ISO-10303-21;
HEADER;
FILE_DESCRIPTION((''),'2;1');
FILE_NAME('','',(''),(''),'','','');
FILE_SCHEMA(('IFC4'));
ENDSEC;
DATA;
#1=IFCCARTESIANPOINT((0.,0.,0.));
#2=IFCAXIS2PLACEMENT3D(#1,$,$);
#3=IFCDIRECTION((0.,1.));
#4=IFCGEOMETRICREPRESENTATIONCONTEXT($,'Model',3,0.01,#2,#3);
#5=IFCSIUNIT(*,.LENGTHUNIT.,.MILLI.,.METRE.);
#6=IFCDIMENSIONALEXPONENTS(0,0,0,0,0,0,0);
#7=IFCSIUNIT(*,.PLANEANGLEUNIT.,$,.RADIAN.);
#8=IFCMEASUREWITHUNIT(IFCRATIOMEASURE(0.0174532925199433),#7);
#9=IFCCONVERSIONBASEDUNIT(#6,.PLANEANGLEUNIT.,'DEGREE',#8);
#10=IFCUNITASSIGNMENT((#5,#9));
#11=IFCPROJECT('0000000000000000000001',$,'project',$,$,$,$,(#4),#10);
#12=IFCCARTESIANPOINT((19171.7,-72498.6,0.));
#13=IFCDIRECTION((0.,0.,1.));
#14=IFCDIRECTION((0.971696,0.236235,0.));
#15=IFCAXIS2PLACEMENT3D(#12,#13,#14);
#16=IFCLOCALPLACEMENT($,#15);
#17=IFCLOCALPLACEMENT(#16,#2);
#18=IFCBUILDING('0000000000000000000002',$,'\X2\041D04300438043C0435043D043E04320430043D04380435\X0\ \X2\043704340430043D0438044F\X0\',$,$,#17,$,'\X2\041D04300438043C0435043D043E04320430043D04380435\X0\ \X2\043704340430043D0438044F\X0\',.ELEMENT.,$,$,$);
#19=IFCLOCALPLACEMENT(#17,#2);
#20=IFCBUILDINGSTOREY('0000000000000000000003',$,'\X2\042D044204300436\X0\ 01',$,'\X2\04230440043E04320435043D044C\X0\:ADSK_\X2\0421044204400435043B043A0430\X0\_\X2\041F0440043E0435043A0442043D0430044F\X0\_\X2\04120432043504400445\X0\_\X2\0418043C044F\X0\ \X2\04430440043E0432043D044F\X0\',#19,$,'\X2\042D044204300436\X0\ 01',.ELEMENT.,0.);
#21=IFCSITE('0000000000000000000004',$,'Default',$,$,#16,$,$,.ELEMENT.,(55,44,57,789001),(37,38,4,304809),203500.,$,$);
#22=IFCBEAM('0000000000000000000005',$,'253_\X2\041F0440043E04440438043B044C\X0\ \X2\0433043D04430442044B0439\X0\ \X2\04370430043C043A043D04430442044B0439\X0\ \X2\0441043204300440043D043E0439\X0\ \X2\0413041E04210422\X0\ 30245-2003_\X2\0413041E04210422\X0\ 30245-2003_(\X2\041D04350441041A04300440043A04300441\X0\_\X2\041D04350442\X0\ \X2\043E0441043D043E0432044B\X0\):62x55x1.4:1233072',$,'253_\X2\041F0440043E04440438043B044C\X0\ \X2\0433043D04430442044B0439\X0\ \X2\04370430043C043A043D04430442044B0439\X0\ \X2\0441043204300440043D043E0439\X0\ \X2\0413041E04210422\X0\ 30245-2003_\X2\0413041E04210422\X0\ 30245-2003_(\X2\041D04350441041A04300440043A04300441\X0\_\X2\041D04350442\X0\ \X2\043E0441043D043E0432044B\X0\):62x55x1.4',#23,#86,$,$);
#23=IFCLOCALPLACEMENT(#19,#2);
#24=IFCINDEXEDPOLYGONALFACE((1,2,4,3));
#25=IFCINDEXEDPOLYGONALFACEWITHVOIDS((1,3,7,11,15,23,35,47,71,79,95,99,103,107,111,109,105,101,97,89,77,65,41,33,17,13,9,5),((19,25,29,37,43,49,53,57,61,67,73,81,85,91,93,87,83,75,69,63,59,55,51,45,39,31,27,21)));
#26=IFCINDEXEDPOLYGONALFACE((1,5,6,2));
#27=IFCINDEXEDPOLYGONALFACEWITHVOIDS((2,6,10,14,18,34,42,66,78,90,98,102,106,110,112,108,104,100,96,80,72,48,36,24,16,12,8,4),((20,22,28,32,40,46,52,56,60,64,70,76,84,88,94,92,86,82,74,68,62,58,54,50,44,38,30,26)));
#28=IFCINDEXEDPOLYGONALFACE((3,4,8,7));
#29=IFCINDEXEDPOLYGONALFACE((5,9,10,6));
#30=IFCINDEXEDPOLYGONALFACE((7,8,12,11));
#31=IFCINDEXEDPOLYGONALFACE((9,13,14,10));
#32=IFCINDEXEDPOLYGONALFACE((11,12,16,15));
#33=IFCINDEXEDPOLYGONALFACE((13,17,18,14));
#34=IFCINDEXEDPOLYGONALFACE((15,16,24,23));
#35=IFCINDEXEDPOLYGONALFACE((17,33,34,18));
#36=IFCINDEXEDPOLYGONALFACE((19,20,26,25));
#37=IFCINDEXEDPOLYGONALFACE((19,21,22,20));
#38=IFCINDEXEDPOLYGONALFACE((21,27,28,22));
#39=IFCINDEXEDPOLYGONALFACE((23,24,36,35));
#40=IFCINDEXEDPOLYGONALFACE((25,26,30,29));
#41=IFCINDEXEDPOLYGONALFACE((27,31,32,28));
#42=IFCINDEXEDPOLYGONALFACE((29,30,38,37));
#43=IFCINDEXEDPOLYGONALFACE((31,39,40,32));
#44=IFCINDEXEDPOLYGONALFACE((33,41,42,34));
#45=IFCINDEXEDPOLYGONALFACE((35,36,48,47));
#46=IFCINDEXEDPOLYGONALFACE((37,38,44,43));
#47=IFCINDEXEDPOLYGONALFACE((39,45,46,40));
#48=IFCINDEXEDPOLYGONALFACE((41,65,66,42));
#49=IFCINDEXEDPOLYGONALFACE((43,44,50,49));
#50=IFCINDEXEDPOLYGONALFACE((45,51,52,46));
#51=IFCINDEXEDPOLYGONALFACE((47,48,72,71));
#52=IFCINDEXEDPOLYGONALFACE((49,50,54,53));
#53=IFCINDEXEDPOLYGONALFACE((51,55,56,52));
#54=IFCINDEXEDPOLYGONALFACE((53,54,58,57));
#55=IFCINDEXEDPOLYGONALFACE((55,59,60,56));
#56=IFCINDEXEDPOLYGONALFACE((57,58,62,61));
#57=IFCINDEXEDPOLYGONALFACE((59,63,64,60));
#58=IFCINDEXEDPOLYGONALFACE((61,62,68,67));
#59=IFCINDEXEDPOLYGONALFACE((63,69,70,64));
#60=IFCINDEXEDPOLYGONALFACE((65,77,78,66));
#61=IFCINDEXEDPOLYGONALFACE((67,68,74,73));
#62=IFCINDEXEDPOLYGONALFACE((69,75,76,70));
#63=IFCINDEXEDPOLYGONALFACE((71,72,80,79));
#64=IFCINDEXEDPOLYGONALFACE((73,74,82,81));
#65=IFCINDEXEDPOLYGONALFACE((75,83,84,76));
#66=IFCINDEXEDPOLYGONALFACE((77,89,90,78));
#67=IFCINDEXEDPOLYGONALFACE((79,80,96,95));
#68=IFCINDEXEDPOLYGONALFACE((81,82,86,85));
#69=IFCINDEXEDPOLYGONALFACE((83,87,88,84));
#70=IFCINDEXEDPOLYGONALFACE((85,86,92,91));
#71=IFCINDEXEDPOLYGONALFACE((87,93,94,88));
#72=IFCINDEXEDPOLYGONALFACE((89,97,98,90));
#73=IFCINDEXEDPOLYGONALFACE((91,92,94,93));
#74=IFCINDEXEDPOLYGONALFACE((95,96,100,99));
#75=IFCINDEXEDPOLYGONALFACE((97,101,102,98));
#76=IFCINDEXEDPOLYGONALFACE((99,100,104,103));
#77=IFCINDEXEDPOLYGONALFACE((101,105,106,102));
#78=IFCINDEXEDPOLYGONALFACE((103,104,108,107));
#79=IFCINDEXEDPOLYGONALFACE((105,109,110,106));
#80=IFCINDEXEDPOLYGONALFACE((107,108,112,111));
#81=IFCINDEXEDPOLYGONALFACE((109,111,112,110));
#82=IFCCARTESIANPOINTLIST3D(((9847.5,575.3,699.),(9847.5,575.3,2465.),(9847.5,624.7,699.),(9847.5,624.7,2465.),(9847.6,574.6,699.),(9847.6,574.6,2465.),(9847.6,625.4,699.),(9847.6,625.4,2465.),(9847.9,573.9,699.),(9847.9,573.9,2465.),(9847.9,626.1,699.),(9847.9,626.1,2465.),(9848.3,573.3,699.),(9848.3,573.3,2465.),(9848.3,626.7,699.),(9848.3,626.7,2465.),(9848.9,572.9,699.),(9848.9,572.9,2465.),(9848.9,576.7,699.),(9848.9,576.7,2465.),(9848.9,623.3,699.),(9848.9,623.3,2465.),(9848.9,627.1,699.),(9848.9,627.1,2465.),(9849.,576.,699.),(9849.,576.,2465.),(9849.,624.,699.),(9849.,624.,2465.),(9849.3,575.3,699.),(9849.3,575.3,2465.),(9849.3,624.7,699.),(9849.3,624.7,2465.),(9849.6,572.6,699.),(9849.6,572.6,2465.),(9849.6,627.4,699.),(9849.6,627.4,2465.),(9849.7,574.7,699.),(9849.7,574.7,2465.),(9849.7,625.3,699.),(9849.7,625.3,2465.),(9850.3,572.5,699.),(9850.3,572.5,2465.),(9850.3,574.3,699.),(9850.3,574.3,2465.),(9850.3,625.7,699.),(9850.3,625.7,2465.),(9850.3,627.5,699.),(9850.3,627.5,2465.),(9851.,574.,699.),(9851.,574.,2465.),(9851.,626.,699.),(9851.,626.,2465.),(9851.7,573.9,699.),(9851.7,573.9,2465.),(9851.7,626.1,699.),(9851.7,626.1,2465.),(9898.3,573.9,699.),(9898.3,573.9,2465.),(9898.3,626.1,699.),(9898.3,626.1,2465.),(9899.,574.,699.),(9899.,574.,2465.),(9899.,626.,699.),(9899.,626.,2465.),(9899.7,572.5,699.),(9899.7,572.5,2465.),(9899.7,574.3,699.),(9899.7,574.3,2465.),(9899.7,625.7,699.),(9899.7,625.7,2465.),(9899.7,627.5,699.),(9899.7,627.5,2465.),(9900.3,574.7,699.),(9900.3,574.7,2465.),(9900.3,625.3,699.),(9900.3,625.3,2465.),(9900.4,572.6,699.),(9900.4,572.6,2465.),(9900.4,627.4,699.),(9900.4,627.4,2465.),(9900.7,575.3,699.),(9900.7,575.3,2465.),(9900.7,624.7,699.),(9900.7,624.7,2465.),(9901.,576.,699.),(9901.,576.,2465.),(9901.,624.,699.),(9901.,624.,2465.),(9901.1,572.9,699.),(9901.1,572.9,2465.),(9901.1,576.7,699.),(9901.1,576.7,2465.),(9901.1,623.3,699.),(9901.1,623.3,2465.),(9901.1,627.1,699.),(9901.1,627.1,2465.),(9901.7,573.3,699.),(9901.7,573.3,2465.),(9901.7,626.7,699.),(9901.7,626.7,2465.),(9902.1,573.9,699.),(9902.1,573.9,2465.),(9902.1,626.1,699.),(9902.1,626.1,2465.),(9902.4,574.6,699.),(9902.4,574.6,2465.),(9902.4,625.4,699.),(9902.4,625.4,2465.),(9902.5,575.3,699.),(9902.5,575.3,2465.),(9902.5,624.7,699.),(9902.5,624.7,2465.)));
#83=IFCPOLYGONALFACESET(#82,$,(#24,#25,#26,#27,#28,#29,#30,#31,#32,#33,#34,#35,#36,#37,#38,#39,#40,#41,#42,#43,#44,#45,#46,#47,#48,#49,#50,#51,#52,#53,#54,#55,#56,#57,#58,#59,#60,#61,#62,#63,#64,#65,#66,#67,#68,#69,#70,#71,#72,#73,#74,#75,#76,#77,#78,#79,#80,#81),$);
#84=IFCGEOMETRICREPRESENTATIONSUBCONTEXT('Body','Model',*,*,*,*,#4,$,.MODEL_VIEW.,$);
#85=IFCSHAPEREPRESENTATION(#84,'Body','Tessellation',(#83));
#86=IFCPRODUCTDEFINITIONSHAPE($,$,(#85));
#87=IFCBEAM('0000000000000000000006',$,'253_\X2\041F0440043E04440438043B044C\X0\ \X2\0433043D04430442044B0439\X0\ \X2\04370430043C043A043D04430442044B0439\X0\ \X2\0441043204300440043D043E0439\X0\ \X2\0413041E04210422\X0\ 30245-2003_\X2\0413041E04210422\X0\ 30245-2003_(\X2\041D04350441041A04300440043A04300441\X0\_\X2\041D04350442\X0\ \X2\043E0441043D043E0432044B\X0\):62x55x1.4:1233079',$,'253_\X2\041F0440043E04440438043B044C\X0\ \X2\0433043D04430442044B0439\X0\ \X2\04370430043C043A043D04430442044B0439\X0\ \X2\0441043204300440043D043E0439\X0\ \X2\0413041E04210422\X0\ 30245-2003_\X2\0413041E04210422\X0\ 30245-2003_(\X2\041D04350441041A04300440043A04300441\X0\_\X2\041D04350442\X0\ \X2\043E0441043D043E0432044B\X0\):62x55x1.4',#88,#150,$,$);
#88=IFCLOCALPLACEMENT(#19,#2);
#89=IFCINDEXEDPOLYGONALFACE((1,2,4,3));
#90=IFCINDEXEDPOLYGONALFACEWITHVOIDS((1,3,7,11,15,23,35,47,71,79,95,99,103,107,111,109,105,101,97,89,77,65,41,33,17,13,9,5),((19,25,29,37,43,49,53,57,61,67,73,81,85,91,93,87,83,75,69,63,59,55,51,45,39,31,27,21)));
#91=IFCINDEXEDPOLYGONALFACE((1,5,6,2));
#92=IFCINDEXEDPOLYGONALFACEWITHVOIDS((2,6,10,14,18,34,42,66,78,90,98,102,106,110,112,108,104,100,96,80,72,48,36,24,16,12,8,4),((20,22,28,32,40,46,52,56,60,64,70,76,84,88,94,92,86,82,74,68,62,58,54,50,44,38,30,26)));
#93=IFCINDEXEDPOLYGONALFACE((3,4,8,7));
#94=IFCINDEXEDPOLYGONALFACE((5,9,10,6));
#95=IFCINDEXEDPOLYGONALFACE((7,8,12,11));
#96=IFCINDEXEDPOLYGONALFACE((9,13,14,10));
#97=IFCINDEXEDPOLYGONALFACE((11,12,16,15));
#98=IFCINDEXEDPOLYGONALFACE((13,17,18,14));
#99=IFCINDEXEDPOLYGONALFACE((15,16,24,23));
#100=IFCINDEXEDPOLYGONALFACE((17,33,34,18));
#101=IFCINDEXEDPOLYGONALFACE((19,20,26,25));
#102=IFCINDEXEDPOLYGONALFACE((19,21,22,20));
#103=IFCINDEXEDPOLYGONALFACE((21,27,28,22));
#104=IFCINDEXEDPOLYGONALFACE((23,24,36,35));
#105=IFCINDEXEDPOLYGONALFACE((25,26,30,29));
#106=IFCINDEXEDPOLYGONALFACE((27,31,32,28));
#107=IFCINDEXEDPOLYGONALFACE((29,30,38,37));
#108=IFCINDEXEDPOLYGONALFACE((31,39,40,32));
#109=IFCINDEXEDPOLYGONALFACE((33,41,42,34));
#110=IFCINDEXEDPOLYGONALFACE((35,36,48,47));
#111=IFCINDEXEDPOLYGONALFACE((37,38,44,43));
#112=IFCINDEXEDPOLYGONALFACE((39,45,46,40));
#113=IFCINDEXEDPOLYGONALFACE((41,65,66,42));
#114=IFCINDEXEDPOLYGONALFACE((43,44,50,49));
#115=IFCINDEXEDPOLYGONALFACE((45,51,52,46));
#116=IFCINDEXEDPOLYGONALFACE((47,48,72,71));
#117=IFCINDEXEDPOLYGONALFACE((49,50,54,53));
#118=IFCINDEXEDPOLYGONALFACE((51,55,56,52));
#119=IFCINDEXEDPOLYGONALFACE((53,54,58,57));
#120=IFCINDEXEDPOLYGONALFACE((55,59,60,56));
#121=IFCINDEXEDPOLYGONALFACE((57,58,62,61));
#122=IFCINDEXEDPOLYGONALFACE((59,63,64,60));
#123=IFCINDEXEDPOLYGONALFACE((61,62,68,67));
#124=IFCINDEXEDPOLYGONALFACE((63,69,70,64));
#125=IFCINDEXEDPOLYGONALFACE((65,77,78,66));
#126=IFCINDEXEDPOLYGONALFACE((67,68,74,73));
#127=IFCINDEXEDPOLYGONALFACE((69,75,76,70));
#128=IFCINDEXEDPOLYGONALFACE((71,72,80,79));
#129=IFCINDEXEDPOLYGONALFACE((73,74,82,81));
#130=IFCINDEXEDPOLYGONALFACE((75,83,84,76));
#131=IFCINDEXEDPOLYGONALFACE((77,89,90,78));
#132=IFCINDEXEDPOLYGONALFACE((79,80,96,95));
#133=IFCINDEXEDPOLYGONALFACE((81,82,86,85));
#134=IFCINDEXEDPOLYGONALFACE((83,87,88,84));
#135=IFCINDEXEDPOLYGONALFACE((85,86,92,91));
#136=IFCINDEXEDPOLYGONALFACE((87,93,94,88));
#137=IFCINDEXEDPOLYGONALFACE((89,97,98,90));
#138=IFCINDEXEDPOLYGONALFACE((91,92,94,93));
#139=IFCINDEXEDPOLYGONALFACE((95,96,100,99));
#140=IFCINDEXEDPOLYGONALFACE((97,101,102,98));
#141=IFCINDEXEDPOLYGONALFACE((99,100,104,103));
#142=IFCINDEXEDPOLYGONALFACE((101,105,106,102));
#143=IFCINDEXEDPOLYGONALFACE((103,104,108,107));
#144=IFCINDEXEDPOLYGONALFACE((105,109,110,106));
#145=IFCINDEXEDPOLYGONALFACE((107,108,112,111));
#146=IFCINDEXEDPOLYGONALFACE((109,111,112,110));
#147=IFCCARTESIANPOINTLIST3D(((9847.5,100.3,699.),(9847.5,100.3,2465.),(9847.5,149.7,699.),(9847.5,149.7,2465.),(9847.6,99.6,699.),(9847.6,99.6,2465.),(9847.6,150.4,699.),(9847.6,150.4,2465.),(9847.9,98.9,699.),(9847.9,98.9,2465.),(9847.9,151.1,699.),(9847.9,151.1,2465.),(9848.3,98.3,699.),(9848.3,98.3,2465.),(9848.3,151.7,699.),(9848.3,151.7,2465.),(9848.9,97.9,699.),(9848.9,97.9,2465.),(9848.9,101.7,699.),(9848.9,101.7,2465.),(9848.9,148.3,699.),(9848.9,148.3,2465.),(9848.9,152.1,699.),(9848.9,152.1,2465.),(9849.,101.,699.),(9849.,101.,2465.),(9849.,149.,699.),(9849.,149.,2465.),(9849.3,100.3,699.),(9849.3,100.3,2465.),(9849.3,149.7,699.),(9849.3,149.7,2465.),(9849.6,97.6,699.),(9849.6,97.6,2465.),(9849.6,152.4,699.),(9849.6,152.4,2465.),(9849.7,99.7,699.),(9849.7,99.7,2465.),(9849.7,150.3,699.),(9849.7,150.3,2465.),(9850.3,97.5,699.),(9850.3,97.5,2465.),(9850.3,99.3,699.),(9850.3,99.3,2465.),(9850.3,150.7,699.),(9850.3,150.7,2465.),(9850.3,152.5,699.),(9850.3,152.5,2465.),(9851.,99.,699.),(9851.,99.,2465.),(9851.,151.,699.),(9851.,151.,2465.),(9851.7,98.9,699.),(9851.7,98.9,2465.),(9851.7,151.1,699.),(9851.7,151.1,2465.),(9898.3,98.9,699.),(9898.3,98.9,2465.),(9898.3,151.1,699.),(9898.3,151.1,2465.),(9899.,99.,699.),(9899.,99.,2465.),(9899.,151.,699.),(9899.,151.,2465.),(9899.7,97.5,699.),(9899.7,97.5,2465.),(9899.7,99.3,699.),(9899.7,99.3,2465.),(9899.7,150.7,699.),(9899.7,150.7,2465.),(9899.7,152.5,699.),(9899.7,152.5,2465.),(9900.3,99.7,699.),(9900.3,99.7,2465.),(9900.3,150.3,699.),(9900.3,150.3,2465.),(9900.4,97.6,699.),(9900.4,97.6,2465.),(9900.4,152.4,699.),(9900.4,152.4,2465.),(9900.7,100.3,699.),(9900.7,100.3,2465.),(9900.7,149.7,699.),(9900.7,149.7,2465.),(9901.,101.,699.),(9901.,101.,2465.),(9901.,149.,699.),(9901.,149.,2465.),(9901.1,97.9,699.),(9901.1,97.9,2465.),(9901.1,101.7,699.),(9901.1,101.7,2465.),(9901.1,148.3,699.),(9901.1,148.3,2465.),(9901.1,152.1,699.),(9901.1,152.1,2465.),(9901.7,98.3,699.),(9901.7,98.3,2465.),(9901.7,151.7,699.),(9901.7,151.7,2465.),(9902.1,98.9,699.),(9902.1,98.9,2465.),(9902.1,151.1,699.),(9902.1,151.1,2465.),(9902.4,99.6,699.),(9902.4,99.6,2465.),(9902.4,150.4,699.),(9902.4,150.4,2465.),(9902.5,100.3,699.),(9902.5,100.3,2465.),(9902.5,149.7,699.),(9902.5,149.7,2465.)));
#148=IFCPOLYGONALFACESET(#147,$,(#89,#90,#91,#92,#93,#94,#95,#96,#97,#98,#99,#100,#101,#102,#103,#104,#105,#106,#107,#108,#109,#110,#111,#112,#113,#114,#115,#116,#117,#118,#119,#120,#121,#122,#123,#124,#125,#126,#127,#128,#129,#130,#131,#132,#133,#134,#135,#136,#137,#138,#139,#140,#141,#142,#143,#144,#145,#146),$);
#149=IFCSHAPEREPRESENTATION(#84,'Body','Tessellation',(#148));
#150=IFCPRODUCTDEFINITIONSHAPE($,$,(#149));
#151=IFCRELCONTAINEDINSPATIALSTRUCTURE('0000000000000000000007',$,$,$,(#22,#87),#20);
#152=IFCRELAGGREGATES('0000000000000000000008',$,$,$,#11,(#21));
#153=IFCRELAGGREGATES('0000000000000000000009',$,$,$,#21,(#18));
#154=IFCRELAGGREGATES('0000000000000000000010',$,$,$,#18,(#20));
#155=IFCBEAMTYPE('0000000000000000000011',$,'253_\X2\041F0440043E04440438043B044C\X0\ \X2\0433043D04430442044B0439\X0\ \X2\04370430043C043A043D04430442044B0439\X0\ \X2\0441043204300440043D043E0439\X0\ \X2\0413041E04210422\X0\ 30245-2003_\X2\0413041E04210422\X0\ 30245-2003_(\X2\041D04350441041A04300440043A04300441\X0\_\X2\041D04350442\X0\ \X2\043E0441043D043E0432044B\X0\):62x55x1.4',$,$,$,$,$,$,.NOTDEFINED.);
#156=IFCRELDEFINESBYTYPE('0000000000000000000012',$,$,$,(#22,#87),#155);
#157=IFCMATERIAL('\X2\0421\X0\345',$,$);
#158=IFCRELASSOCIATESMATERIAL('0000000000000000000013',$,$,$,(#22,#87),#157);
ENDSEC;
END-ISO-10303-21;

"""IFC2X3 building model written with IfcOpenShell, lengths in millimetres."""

from ifc_helpers import new_model, entity, si_unit, converted_unit, direction, frame, frame_2d, origin, place, context, subcontext, project, spatial, polyline, circle_curve, parameter, trimmed, segment, composite_curve, outline, extrude, material, type_object, element, save


model = new_model("IFC2X3")

# Units and contexts
model_context = context("Model", 3, precision=0.01, world=origin(), true_north=direction((0.0, 1.0)))
body_context = subcontext(model_context, "Body", "Model", "MODEL_VIEW")
ifc_project = project(units=[si_unit("LENGTHUNIT", "METRE", prefix="MILLI"), converted_unit("PLANEANGLEUNIT", "DEGREE", entity("IfcRatioMeasure", 0.0174532925199433), si_unit("PLANEANGLEUNIT", "RADIAN"), dimensions=[0, 0, 0, 0, 0, 0, 0])], contexts=[model_context])

# Site, building, storey
site_placement = place(None, frame((19171.7, -72498.6, 0.0), z_axis=(0.0, 0.0, 1.0), x_axis=(0.971696, 0.236235, 0.0)))
site = spatial("IfcSite", under=ifc_project, at=site_placement, Name="Default", CompositionType="ELEMENT", RefLatitude=(55, 44, 57, 789001), RefLongitude=(37, 38, 4, 304809), RefElevation=203500.0)
building_placement = place(site_placement, origin())
building = spatial("IfcBuilding", under=site, at=building_placement, Name="Наименование здания", LongName="Наименование здания", CompositionType="ELEMENT")
storey_placement = place(building_placement, origin())
storey = spatial("IfcBuildingStorey", under=building, at=storey_placement, Name="Этаж 01", ObjectType="Уровень:ADSK_Стрелка_Проектная_Вверх_Имя уровня", LongName="Этаж 01", CompositionType="ELEMENT", Elevation=0.0)

# Beams
ifc_material_1 = material(Name="С345")
beam_type_1 = type_object("IfcBeamType", Name="253_Профиль гнутый замкнутый сварной ГОСТ 30245-2003_ГОСТ 30245-2003_(НесКаркас_Нет основы):62x55x1.4", PredefinedType="NOTDEFINED")
beam_1_placement = place(storey_placement, frame((9845.9, 570.9, 699.0), z_axis=(1.0, 0.0, 0.0), x_axis=(0.0, 0.0, 1.0)))
element("IfcBeam", 1, at=beam_1_placement, inside=storey, type_object=beam_type_1, material=ifc_material_1, Name="253_Профиль гнутый замкнутый сварной ГОСТ 30245-2003_ГОСТ 30245-2003_(НесКаркас_Нет основы):62x55x1.4:1233072", ObjectType="253_Профиль гнутый замкнутый сварной ГОСТ 30245-2003_ГОСТ 30245-2003_(НесКаркас_Нет основы):62x55x1.4", context=body_context, shape_type="SweptSolid", body=[
    extrude(outline(composite_curve([segment(trimmed(circle_curve(frame_2d((24.7, -24.7), x_axis=(1.0, 0.0)), 2.8), [parameter(270.0)], [parameter(0.0)], True, "PARAMETER"), True, "CONTINUOUS"), segment(polyline([(27.5, -24.7), (27.5, 24.7)]), True, "CONTINUOUS"), segment(trimmed(circle_curve(frame_2d((24.7, 24.7), x_axis=(1.0, 0.0)), 2.8), [parameter(0.0)], [parameter(90.0)], True, "PARAMETER"), True, "CONTINUOUS"), segment(polyline([(24.7, 27.5), (-24.7, 27.5)]), True, "CONTINUOUS"), segment(trimmed(circle_curve(frame_2d((-24.7, 24.7), x_axis=(1.0, 0.0)), 2.8), [parameter(90.0)], [parameter(180.0)], True, "PARAMETER"), True, "CONTINUOUS"), segment(polyline([(-27.5, 24.7), (-27.5, -24.7)]), True, "CONTINUOUS"), segment(trimmed(circle_curve(frame_2d((-24.7, -24.7), x_axis=(1.0, 0.0)), 2.8), [parameter(180.0)], [parameter(270.0)], True, "PARAMETER"), True, "CONTINUOUS"), segment(polyline([(-24.7, -27.5), (24.7, -27.5)]), True, "CONTINUOUS")], self_intersect=False), holes=[composite_curve([segment(polyline([(23.3, -26.1), (-23.3, -26.1)]), True, "CONTINUOUS"), segment(trimmed(circle_curve(frame_2d((-23.3, -23.3), x_axis=(1.0, 0.0)), 2.8), [parameter(180.0)], [parameter(270.0)], True, "PARAMETER"), False, "CONTINUOUS"), segment(polyline([(-26.1, -23.3), (-26.1, 23.3)]), True, "CONTINUOUS"), segment(trimmed(circle_curve(frame_2d((-23.3, 23.3), x_axis=(1.0, 0.0)), 2.8), [parameter(90.0)], [parameter(180.0)], True, "PARAMETER"), False, "CONTINUOUS"), segment(polyline([(-23.3, 26.1), (23.3, 26.1)]), True, "CONTINUOUS"), segment(trimmed(circle_curve(frame_2d((23.3, 23.3), x_axis=(1.0, 0.0)), 2.8), [parameter(0.0)], [parameter(90.0)], True, "PARAMETER"), False, "CONTINUOUS"), segment(polyline([(26.1, 23.3), (26.1, -23.3)]), True, "CONTINUOUS"), segment(trimmed(circle_curve(frame_2d((23.3, -23.3), x_axis=(1.0, 0.0)), 2.8), [parameter(270.0)], [parameter(0.0)], True, "PARAMETER"), False, "CONTINUOUS")], self_intersect=False)]), frame((0.0, -29.1, 29.1), z_axis=(1.0, 0.0, 0.0), x_axis=(0.0, -1.0, 0.0)), (0.0, 0.0, 1.0), 1766.0),
])
beam_2_placement = place(storey_placement, frame((9845.9, 95.9, 699.0), z_axis=(1.0, 0.0, 0.0), x_axis=(0.0, 0.0, 1.0)))
element("IfcBeam", 2, at=beam_2_placement, inside=storey, type_object=beam_type_1, material=ifc_material_1, Name="253_Профиль гнутый замкнутый сварной ГОСТ 30245-2003_ГОСТ 30245-2003_(НесКаркас_Нет основы):62x55x1.4:1233079", ObjectType="253_Профиль гнутый замкнутый сварной ГОСТ 30245-2003_ГОСТ 30245-2003_(НесКаркас_Нет основы):62x55x1.4", context=body_context, shape_type="SweptSolid", body=[
    extrude(outline(composite_curve([segment(trimmed(circle_curve(frame_2d((24.7, -24.7), x_axis=(1.0, 0.0)), 2.8), [parameter(270.0)], [parameter(0.0)], True, "PARAMETER"), True, "CONTINUOUS"), segment(polyline([(27.5, -24.7), (27.5, 24.7)]), True, "CONTINUOUS"), segment(trimmed(circle_curve(frame_2d((24.7, 24.7), x_axis=(1.0, 0.0)), 2.8), [parameter(0.0)], [parameter(90.0)], True, "PARAMETER"), True, "CONTINUOUS"), segment(polyline([(24.7, 27.5), (-24.7, 27.5)]), True, "CONTINUOUS"), segment(trimmed(circle_curve(frame_2d((-24.7, 24.7), x_axis=(1.0, 0.0)), 2.8), [parameter(90.0)], [parameter(180.0)], True, "PARAMETER"), True, "CONTINUOUS"), segment(polyline([(-27.5, 24.7), (-27.5, -24.7)]), True, "CONTINUOUS"), segment(trimmed(circle_curve(frame_2d((-24.7, -24.7), x_axis=(1.0, 0.0)), 2.8), [parameter(180.0)], [parameter(270.0)], True, "PARAMETER"), True, "CONTINUOUS"), segment(polyline([(-24.7, -27.5), (24.7, -27.5)]), True, "CONTINUOUS")], self_intersect=False), holes=[composite_curve([segment(polyline([(23.3, -26.1), (-23.3, -26.1)]), True, "CONTINUOUS"), segment(trimmed(circle_curve(frame_2d((-23.3, -23.3), x_axis=(1.0, 0.0)), 2.8), [parameter(180.0)], [parameter(270.0)], True, "PARAMETER"), False, "CONTINUOUS"), segment(polyline([(-26.1, -23.3), (-26.1, 23.3)]), True, "CONTINUOUS"), segment(trimmed(circle_curve(frame_2d((-23.3, 23.3), x_axis=(1.0, 0.0)), 2.8), [parameter(90.0)], [parameter(180.0)], True, "PARAMETER"), False, "CONTINUOUS"), segment(polyline([(-23.3, 26.1), (23.3, 26.1)]), True, "CONTINUOUS"), segment(trimmed(circle_curve(frame_2d((23.3, 23.3), x_axis=(1.0, 0.0)), 2.8), [parameter(0.0)], [parameter(90.0)], True, "PARAMETER"), False, "CONTINUOUS"), segment(polyline([(26.1, 23.3), (26.1, -23.3)]), True, "CONTINUOUS"), segment(trimmed(circle_curve(frame_2d((23.3, -23.3), x_axis=(1.0, 0.0)), 2.8), [parameter(270.0)], [parameter(0.0)], True, "PARAMETER"), False, "CONTINUOUS")], self_intersect=False)]), frame((0.0, -29.1, 29.1), z_axis=(1.0, 0.0, 0.0), x_axis=(0.0, -1.0, 0.0)), (0.0, 0.0, 1.0), 1766.0),
])

save(model, "model.ifc")
